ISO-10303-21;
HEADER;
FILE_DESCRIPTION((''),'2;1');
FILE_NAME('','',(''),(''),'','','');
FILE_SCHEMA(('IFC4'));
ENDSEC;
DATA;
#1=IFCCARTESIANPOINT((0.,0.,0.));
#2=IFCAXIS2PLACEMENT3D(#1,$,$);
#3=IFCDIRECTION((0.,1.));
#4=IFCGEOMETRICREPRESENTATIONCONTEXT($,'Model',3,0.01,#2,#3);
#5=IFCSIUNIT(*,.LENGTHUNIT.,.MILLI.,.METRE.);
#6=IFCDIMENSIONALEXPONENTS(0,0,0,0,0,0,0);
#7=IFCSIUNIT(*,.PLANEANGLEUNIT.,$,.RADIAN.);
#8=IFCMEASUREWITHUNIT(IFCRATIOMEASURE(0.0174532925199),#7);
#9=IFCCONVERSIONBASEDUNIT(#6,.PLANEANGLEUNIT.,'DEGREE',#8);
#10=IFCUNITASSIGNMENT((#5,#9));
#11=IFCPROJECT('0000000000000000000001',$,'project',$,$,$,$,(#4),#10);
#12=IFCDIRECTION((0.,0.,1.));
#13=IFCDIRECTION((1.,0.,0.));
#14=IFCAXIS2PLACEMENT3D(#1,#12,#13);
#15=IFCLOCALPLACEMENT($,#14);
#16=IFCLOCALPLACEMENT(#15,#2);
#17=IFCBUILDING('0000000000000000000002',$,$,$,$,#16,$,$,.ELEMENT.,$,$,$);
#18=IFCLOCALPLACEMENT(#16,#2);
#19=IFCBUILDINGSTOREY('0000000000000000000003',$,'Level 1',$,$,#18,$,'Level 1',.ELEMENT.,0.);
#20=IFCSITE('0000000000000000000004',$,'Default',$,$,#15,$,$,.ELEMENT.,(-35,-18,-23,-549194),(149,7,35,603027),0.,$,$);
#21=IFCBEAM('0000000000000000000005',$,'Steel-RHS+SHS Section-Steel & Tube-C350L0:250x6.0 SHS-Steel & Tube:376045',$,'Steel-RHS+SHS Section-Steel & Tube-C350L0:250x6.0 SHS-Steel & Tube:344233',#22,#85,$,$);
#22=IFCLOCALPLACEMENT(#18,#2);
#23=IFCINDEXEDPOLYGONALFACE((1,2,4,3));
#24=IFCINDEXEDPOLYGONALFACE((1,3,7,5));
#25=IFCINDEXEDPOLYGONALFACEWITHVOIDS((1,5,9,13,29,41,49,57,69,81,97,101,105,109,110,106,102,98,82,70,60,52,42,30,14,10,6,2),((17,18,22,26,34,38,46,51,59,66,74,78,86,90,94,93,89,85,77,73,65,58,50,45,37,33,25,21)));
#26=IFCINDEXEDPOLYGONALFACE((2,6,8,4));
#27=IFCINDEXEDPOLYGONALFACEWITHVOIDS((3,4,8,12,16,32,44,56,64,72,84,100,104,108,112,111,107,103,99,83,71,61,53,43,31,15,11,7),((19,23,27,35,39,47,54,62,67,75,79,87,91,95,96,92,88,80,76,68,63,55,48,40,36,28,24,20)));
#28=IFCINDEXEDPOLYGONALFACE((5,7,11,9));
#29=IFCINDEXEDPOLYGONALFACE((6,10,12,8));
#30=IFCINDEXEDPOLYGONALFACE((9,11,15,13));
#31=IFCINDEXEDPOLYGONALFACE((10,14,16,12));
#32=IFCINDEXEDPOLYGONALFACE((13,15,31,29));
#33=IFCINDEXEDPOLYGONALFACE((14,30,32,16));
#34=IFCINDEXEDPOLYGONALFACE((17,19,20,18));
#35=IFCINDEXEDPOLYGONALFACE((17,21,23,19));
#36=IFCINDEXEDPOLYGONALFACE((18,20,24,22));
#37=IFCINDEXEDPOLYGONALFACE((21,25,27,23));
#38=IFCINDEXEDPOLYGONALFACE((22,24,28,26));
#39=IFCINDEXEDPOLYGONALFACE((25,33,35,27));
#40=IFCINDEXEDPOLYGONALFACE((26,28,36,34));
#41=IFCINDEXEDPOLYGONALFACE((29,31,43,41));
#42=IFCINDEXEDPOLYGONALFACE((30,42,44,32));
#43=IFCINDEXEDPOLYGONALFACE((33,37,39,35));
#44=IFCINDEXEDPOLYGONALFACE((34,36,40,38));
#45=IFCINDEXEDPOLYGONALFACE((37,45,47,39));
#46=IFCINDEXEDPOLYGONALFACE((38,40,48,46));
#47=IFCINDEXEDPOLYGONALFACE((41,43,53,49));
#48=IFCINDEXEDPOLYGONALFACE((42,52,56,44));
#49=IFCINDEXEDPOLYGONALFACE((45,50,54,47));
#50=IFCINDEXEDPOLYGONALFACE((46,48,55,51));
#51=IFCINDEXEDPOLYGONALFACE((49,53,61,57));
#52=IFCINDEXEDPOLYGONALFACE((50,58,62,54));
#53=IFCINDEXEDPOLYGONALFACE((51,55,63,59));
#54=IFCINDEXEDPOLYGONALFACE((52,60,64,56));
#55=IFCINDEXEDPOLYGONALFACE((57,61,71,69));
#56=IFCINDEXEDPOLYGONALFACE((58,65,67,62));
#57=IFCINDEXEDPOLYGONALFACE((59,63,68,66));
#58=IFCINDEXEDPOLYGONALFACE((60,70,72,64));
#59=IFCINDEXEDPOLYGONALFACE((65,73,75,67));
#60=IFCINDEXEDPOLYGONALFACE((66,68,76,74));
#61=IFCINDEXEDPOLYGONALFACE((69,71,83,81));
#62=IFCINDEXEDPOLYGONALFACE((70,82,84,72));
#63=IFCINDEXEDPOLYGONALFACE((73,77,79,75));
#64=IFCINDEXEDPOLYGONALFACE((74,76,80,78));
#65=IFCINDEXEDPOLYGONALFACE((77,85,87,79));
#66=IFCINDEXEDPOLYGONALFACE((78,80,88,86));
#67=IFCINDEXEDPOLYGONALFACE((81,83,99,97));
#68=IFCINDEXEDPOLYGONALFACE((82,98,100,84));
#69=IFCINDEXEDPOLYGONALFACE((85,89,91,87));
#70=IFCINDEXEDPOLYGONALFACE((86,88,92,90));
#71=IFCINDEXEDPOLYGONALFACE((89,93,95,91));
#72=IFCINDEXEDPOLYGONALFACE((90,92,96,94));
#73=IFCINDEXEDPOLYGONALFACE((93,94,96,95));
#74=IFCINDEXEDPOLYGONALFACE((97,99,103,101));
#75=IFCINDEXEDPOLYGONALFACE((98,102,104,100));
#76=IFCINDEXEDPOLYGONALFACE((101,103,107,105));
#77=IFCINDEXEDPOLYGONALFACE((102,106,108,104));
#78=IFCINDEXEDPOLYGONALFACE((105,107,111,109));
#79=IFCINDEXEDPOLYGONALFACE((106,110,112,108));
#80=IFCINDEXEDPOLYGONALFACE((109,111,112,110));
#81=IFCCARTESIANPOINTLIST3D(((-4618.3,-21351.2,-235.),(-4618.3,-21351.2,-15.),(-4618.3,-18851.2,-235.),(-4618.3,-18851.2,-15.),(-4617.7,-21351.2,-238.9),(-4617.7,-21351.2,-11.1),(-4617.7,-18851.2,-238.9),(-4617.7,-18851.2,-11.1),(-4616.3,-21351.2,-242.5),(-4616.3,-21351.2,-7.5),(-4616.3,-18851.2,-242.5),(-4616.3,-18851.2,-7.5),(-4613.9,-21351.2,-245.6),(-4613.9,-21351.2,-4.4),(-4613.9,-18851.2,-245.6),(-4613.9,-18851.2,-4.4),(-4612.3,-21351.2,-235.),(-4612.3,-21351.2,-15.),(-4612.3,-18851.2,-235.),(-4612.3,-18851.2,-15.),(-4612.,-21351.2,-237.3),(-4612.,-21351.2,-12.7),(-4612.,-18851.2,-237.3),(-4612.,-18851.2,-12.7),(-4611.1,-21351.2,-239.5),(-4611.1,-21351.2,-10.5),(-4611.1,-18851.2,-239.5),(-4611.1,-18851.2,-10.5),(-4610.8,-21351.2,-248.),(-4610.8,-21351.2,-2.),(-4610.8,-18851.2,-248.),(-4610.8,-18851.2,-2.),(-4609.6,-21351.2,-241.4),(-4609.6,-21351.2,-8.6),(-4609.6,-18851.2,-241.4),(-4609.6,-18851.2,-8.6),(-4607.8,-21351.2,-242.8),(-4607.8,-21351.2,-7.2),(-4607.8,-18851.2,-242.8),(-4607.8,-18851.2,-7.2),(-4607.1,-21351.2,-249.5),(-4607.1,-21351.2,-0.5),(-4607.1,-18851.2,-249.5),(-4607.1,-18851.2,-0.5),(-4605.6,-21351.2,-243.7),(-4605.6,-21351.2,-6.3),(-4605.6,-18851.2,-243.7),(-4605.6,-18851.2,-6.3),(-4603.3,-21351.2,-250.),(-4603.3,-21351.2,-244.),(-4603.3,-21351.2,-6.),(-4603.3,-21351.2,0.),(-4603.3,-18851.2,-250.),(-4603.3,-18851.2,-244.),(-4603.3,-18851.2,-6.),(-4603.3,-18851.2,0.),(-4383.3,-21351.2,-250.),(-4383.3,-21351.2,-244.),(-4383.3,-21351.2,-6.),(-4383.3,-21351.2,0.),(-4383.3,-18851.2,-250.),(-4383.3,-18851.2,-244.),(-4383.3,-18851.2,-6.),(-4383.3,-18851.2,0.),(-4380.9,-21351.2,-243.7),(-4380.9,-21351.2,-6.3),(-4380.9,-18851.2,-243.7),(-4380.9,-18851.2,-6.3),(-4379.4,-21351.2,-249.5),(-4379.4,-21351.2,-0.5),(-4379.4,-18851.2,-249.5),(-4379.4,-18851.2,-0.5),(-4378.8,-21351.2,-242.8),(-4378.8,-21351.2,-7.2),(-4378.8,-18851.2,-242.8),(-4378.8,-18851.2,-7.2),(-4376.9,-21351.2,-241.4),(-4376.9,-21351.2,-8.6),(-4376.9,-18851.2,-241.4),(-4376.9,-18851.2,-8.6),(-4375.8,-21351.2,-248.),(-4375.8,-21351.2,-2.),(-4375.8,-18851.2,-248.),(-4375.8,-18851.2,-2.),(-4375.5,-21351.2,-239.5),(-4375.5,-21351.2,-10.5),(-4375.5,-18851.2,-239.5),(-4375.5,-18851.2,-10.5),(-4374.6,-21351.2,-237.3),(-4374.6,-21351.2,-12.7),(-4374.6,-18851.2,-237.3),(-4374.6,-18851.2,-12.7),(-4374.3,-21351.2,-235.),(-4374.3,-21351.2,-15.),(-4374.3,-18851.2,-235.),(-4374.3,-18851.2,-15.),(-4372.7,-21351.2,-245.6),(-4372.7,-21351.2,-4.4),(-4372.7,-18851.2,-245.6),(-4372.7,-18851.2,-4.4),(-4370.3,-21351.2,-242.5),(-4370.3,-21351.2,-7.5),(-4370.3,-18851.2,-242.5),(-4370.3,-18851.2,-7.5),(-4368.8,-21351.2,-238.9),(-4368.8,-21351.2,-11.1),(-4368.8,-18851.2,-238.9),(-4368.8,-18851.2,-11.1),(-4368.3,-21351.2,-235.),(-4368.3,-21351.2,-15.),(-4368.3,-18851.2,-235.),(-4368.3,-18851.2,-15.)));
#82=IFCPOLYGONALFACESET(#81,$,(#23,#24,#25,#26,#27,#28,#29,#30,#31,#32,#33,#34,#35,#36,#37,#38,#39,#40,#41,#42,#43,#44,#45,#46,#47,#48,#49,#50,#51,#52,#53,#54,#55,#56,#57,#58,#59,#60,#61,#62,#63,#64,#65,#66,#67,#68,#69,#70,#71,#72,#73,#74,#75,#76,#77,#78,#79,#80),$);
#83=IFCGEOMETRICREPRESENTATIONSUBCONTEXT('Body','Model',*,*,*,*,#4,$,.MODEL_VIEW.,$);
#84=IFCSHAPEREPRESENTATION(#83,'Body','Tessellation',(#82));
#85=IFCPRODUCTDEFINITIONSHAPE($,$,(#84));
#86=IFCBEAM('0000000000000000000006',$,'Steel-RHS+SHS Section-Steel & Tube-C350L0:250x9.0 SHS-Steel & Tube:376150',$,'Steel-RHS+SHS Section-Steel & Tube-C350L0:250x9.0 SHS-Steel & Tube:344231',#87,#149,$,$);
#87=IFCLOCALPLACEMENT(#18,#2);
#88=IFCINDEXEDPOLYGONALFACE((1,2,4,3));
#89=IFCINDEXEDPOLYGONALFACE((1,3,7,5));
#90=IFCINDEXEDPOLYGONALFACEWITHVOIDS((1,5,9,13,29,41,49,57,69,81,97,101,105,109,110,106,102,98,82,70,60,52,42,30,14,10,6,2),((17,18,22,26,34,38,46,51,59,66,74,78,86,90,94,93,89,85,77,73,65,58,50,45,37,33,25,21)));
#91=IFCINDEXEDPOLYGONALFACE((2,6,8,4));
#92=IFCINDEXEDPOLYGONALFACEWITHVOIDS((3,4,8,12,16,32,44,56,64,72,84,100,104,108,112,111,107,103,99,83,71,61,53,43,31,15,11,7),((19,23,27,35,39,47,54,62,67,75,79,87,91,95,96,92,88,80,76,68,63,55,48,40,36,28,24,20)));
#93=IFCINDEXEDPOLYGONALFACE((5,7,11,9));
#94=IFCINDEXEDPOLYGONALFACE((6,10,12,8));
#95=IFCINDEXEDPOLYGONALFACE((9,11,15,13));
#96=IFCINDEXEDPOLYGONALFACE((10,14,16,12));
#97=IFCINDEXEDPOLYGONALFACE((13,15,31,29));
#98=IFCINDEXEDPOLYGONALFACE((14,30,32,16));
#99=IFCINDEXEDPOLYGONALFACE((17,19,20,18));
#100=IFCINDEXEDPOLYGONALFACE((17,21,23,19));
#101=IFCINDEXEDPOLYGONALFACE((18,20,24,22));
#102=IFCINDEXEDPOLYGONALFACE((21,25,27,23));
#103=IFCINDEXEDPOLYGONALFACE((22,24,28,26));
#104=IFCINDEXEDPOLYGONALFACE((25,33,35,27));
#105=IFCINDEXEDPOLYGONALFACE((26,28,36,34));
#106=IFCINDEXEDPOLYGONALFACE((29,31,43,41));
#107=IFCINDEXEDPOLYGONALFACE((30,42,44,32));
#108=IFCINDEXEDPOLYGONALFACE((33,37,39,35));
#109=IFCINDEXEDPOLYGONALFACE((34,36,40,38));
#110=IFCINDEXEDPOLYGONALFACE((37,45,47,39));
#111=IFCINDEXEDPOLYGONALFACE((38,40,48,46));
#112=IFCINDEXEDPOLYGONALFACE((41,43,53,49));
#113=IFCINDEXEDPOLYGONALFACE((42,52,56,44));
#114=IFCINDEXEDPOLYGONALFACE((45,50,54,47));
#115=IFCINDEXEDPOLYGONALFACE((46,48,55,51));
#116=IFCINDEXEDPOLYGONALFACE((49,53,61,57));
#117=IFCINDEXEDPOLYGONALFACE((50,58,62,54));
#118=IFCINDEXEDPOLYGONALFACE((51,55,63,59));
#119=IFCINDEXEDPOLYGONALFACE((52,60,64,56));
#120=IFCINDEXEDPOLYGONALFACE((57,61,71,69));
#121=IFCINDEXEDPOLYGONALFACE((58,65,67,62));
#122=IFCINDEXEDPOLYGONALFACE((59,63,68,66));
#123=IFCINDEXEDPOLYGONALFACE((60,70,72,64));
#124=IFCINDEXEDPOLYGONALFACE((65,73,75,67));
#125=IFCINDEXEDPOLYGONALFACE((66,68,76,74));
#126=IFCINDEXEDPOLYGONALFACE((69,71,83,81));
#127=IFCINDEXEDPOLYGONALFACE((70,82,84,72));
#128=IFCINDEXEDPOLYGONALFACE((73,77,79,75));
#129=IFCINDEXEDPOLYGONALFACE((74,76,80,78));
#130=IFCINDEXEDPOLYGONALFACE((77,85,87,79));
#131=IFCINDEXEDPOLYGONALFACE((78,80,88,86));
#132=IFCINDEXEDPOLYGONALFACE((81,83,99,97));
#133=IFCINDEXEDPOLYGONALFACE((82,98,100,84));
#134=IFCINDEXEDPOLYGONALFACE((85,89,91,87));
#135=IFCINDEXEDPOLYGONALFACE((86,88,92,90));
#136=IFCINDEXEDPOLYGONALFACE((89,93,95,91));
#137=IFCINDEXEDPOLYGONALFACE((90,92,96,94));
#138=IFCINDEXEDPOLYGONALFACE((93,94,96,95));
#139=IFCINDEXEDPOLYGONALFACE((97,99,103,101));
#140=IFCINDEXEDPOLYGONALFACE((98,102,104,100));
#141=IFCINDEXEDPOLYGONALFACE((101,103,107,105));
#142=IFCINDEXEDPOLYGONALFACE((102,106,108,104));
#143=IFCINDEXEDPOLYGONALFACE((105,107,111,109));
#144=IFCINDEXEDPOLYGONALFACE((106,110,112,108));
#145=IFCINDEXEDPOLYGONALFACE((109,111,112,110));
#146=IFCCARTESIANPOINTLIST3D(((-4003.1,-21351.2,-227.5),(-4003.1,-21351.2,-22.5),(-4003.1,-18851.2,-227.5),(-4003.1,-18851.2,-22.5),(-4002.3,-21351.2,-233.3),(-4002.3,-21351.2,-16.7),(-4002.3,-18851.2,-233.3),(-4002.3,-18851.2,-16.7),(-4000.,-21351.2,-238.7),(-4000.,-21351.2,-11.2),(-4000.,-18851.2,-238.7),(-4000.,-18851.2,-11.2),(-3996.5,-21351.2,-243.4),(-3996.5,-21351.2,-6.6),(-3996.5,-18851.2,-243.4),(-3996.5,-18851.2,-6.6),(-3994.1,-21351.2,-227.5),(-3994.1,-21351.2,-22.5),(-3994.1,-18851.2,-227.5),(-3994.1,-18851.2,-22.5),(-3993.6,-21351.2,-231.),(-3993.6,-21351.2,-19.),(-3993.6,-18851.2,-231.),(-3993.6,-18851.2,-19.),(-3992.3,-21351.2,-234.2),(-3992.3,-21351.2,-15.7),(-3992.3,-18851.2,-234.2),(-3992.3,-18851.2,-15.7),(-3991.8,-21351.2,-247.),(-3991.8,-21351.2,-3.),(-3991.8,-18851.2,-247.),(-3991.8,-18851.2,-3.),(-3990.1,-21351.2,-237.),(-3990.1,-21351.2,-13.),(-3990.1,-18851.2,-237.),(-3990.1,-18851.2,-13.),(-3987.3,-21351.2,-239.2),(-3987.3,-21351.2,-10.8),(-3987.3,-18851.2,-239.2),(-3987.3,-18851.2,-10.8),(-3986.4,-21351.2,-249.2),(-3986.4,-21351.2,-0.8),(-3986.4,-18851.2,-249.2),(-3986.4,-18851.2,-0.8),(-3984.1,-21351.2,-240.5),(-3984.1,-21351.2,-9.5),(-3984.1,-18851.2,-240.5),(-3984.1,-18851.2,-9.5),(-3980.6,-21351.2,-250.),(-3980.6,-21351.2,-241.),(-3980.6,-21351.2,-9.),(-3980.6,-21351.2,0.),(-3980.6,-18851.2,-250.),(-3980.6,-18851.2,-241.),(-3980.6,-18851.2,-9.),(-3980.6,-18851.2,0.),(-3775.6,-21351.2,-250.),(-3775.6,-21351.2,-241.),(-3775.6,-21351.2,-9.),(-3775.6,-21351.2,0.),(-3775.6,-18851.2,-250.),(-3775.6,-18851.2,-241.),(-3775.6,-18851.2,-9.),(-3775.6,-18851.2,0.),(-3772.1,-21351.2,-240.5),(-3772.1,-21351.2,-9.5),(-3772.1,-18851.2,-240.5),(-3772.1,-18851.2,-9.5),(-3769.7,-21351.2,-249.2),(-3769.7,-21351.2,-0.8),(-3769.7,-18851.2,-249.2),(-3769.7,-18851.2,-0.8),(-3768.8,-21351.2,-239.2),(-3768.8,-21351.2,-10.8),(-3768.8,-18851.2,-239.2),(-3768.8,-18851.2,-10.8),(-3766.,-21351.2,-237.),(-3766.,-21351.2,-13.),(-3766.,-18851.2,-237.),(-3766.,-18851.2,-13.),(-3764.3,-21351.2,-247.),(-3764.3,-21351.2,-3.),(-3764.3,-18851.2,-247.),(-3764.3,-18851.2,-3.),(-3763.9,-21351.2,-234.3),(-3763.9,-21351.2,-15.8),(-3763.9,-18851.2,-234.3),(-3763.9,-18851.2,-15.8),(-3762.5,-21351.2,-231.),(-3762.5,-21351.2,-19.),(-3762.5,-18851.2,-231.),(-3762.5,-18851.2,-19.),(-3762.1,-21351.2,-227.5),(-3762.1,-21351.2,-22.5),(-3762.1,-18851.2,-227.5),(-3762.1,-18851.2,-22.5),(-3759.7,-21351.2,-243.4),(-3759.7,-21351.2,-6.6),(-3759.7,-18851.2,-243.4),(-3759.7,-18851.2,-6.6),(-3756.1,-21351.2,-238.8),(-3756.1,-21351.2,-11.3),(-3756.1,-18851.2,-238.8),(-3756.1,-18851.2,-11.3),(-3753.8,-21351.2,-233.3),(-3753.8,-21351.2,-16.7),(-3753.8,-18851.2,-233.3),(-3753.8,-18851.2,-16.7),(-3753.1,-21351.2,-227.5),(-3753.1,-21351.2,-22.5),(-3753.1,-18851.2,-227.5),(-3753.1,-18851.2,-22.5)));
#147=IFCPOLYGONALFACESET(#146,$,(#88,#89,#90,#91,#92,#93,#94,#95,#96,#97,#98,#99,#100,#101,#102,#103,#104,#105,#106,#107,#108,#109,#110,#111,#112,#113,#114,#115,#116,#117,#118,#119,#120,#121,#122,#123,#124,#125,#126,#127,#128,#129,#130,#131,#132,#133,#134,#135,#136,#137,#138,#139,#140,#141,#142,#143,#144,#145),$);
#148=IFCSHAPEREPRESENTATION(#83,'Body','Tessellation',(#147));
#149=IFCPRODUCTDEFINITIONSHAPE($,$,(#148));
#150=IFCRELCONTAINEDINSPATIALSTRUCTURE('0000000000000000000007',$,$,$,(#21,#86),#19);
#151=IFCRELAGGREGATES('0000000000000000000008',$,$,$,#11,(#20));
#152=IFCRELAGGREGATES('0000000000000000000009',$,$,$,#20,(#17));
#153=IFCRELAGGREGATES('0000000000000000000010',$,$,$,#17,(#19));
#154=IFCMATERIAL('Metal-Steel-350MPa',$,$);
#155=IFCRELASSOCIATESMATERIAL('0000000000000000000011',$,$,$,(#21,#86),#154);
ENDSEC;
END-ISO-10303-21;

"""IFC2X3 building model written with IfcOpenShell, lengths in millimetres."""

from ifc_helpers import new_model, entity, si_unit, converted_unit, direction, frame, frame_2d, origin, origin_with_axes, place, context, subcontext, project, spatial, polyline, circle_curve, parameter, trimmed, segment, composite_curve, outline, extrude, material, element, save


model = new_model("IFC2X3")

# Units and contexts
model_context = context("Model", 3, precision=0.01, world=origin(), true_north=direction((0.0, 1.0)))
body_context = subcontext(model_context, "Body", "Model", "MODEL_VIEW")
ifc_project = project(units=[si_unit("LENGTHUNIT", "METRE", prefix="MILLI"), converted_unit("PLANEANGLEUNIT", "DEGREE", entity("IfcRatioMeasure", 0.0174532925199), si_unit("PLANEANGLEUNIT", "RADIAN"), dimensions=[0, 0, 0, 0, 0, 0, 0])], contexts=[model_context])

# Site, building, storey
site_placement = place(None, origin_with_axes())
site = spatial("IfcSite", under=ifc_project, at=site_placement, Name="Default", CompositionType="ELEMENT", RefLatitude=(-35, -18, -23, -549194), RefLongitude=(149, 7, 35, 603027), RefElevation=0.0)
building_placement = place(site_placement, origin())
building = spatial("IfcBuilding", under=site, at=building_placement, CompositionType="ELEMENT")
storey_placement = place(building_placement, origin())
storey = spatial("IfcBuildingStorey", under=building, at=storey_placement, Name="Level 1", LongName="Level 1", CompositionType="ELEMENT", Elevation=0.0)

# Beams
ifc_material = material(Name="Metal-Steel-350MPa")
beam_1_placement = place(storey_placement, frame((-4493.3, -18851.2, 0.0), z_axis=(0.0, 0.0, 1.0), x_axis=(0.0, -1.0, 0.0)))
element("IfcBeam", 1, at=beam_1_placement, inside=storey, material=ifc_material, Name="Steel-RHS+SHS Section-Steel & Tube-C350L0:250x6.0 SHS-Steel & Tube:376045", ObjectType="Steel-RHS+SHS Section-Steel & Tube-C350L0:250x6.0 SHS-Steel & Tube:344233", context=body_context, shape_type="SweptSolid", body=[
    extrude(outline(composite_curve([segment(trimmed(circle_curve(frame_2d((-110.0, -110.0), x_axis=(1.0, 0.0)), 15.0), [parameter(180.0)], [parameter(270.0)], True, "PARAMETER"), True, "CONTINUOUS"), segment(polyline([(-110.0, -125.0), (110.0, -125.0)]), True, "CONTINUOUS"), segment(trimmed(circle_curve(frame_2d((110.0, -110.0), x_axis=(1.0, 0.0)), 15.0), [parameter(270.0)], [parameter(0.0)], True, "PARAMETER"), True, "CONTINUOUS"), segment(polyline([(125.0, -110.0), (125.0, 110.0)]), True, "CONTINUOUS"), segment(trimmed(circle_curve(frame_2d((110.0, 110.0), x_axis=(1.0, 0.0)), 15.0), [parameter(0.0)], [parameter(90.0)], True, "PARAMETER"), True, "CONTINUOUS"), segment(polyline([(110.0, 125.0), (-110.0, 125.0)]), True, "CONTINUOUS"), segment(trimmed(circle_curve(frame_2d((-110.0, 110.0), x_axis=(1.0, 0.0)), 15.0), [parameter(90.0)], [parameter(180.0)], True, "PARAMETER"), True, "CONTINUOUS"), segment(polyline([(-125.0, 110.0), (-125.0, -110.0)]), True, "CONTINUOUS")], self_intersect=False), holes=[composite_curve([segment(polyline([(110.0, -119.0), (-110.0, -119.0)]), True, "CONTINUOUS"), segment(trimmed(circle_curve(frame_2d((-110.0, -110.0), x_axis=(1.0, 0.0)), 9.0), [parameter(180.0)], [parameter(270.0)], True, "PARAMETER"), False, "CONTINUOUS"), segment(polyline([(-119.0, -110.0), (-119.0, 110.0)]), True, "CONTINUOUS"), segment(trimmed(circle_curve(frame_2d((-110.0, 110.0), x_axis=(1.0, 0.0)), 9.0), [parameter(90.0)], [parameter(180.0)], True, "PARAMETER"), False, "CONTINUOUS"), segment(polyline([(-110.0, 119.0), (110.0, 119.0)]), True, "CONTINUOUS"), segment(trimmed(circle_curve(frame_2d((110.0, 110.0), x_axis=(1.0, 0.0)), 9.0), [parameter(360.0)], [parameter(90.0)], True, "PARAMETER"), False, "CONTINUOUS"), segment(polyline([(119.0, 110.0), (119.0, -110.0)]), True, "CONTINUOUS"), segment(trimmed(circle_curve(frame_2d((110.0, -110.0), x_axis=(1.0, 0.0)), 9.0), [parameter(270.0)], [parameter(0.0)], True, "PARAMETER"), False, "CONTINUOUS")], self_intersect=False)]), frame((0.0, 0.0, -125.0), z_axis=(1.0, 0.0, 0.0), x_axis=(0.0, -1.0, 0.0)), (0.0, 0.0, 1.0), 2500.0),
])
beam_2_placement = place(storey_placement, frame((-3878.1, -18851.2, 0.0), z_axis=(0.0, 0.0, 1.0), x_axis=(0.0, -1.0, 0.0)))
element("IfcBeam", 2, at=beam_2_placement, inside=storey, material=ifc_material, Name="Steel-RHS+SHS Section-Steel & Tube-C350L0:250x9.0 SHS-Steel & Tube:376150", ObjectType="Steel-RHS+SHS Section-Steel & Tube-C350L0:250x9.0 SHS-Steel & Tube:344231", context=body_context, shape_type="SweptSolid", body=[
    extrude(outline(composite_curve([segment(trimmed(circle_curve(frame_2d((-102.5, -102.5), x_axis=(1.0, 0.0)), 22.5), [parameter(180.0)], [parameter(270.0)], True, "PARAMETER"), True, "CONTINUOUS"), segment(polyline([(-102.5, -125.0), (102.5, -125.0)]), True, "CONTINUOUS"), segment(trimmed(circle_curve(frame_2d((102.5, -102.5), x_axis=(1.0, 0.0)), 22.5), [parameter(270.0)], [parameter(0.0)], True, "PARAMETER"), True, "CONTINUOUS"), segment(polyline([(125.0, -102.5), (125.0, 102.5)]), True, "CONTINUOUS"), segment(trimmed(circle_curve(frame_2d((102.5, 102.5), x_axis=(1.0, 0.0)), 22.5), [parameter(0.0)], [parameter(90.0)], True, "PARAMETER"), True, "CONTINUOUS"), segment(polyline([(102.5, 125.0), (-102.5, 125.0)]), True, "CONTINUOUS"), segment(trimmed(circle_curve(frame_2d((-102.5, 102.5), x_axis=(1.0, 0.0)), 22.5), [parameter(90.0)], [parameter(180.0)], True, "PARAMETER"), True, "CONTINUOUS"), segment(polyline([(-125.0, 102.5), (-125.0, -102.5)]), True, "CONTINUOUS")], self_intersect=False), holes=[composite_curve([segment(polyline([(102.5, -116.0), (-102.5, -116.0)]), True, "CONTINUOUS"), segment(trimmed(circle_curve(frame_2d((-102.5, -102.5), x_axis=(1.0, 0.0)), 13.5), [parameter(180.0)], [parameter(270.0)], True, "PARAMETER"), False, "CONTINUOUS"), segment(polyline([(-116.0, -102.5), (-116.0, 102.5)]), True, "CONTINUOUS"), segment(trimmed(circle_curve(frame_2d((-102.5, 102.5), x_axis=(1.0, 0.0)), 13.5), [parameter(90.0)], [parameter(180.0)], True, "PARAMETER"), False, "CONTINUOUS"), segment(polyline([(-102.5, 116.0), (102.5, 116.0)]), True, "CONTINUOUS"), segment(trimmed(circle_curve(frame_2d((102.5, 102.5), x_axis=(1.0, 0.0)), 13.5), [parameter(360.0)], [parameter(90.0)], True, "PARAMETER"), False, "CONTINUOUS"), segment(polyline([(116.0, 102.5), (116.0, -102.5)]), True, "CONTINUOUS"), segment(trimmed(circle_curve(frame_2d((102.5, -102.5), x_axis=(1.0, 0.0)), 13.5), [parameter(270.0)], [parameter(360.0)], True, "PARAMETER"), False, "CONTINUOUS")], self_intersect=False)]), frame((0.0, 0.0, -125.0), z_axis=(1.0, 0.0, 0.0), x_axis=(0.0, -1.0, 0.0)), (0.0, 0.0, 1.0), 2500.0),
])

save(model, "model.ifc")
